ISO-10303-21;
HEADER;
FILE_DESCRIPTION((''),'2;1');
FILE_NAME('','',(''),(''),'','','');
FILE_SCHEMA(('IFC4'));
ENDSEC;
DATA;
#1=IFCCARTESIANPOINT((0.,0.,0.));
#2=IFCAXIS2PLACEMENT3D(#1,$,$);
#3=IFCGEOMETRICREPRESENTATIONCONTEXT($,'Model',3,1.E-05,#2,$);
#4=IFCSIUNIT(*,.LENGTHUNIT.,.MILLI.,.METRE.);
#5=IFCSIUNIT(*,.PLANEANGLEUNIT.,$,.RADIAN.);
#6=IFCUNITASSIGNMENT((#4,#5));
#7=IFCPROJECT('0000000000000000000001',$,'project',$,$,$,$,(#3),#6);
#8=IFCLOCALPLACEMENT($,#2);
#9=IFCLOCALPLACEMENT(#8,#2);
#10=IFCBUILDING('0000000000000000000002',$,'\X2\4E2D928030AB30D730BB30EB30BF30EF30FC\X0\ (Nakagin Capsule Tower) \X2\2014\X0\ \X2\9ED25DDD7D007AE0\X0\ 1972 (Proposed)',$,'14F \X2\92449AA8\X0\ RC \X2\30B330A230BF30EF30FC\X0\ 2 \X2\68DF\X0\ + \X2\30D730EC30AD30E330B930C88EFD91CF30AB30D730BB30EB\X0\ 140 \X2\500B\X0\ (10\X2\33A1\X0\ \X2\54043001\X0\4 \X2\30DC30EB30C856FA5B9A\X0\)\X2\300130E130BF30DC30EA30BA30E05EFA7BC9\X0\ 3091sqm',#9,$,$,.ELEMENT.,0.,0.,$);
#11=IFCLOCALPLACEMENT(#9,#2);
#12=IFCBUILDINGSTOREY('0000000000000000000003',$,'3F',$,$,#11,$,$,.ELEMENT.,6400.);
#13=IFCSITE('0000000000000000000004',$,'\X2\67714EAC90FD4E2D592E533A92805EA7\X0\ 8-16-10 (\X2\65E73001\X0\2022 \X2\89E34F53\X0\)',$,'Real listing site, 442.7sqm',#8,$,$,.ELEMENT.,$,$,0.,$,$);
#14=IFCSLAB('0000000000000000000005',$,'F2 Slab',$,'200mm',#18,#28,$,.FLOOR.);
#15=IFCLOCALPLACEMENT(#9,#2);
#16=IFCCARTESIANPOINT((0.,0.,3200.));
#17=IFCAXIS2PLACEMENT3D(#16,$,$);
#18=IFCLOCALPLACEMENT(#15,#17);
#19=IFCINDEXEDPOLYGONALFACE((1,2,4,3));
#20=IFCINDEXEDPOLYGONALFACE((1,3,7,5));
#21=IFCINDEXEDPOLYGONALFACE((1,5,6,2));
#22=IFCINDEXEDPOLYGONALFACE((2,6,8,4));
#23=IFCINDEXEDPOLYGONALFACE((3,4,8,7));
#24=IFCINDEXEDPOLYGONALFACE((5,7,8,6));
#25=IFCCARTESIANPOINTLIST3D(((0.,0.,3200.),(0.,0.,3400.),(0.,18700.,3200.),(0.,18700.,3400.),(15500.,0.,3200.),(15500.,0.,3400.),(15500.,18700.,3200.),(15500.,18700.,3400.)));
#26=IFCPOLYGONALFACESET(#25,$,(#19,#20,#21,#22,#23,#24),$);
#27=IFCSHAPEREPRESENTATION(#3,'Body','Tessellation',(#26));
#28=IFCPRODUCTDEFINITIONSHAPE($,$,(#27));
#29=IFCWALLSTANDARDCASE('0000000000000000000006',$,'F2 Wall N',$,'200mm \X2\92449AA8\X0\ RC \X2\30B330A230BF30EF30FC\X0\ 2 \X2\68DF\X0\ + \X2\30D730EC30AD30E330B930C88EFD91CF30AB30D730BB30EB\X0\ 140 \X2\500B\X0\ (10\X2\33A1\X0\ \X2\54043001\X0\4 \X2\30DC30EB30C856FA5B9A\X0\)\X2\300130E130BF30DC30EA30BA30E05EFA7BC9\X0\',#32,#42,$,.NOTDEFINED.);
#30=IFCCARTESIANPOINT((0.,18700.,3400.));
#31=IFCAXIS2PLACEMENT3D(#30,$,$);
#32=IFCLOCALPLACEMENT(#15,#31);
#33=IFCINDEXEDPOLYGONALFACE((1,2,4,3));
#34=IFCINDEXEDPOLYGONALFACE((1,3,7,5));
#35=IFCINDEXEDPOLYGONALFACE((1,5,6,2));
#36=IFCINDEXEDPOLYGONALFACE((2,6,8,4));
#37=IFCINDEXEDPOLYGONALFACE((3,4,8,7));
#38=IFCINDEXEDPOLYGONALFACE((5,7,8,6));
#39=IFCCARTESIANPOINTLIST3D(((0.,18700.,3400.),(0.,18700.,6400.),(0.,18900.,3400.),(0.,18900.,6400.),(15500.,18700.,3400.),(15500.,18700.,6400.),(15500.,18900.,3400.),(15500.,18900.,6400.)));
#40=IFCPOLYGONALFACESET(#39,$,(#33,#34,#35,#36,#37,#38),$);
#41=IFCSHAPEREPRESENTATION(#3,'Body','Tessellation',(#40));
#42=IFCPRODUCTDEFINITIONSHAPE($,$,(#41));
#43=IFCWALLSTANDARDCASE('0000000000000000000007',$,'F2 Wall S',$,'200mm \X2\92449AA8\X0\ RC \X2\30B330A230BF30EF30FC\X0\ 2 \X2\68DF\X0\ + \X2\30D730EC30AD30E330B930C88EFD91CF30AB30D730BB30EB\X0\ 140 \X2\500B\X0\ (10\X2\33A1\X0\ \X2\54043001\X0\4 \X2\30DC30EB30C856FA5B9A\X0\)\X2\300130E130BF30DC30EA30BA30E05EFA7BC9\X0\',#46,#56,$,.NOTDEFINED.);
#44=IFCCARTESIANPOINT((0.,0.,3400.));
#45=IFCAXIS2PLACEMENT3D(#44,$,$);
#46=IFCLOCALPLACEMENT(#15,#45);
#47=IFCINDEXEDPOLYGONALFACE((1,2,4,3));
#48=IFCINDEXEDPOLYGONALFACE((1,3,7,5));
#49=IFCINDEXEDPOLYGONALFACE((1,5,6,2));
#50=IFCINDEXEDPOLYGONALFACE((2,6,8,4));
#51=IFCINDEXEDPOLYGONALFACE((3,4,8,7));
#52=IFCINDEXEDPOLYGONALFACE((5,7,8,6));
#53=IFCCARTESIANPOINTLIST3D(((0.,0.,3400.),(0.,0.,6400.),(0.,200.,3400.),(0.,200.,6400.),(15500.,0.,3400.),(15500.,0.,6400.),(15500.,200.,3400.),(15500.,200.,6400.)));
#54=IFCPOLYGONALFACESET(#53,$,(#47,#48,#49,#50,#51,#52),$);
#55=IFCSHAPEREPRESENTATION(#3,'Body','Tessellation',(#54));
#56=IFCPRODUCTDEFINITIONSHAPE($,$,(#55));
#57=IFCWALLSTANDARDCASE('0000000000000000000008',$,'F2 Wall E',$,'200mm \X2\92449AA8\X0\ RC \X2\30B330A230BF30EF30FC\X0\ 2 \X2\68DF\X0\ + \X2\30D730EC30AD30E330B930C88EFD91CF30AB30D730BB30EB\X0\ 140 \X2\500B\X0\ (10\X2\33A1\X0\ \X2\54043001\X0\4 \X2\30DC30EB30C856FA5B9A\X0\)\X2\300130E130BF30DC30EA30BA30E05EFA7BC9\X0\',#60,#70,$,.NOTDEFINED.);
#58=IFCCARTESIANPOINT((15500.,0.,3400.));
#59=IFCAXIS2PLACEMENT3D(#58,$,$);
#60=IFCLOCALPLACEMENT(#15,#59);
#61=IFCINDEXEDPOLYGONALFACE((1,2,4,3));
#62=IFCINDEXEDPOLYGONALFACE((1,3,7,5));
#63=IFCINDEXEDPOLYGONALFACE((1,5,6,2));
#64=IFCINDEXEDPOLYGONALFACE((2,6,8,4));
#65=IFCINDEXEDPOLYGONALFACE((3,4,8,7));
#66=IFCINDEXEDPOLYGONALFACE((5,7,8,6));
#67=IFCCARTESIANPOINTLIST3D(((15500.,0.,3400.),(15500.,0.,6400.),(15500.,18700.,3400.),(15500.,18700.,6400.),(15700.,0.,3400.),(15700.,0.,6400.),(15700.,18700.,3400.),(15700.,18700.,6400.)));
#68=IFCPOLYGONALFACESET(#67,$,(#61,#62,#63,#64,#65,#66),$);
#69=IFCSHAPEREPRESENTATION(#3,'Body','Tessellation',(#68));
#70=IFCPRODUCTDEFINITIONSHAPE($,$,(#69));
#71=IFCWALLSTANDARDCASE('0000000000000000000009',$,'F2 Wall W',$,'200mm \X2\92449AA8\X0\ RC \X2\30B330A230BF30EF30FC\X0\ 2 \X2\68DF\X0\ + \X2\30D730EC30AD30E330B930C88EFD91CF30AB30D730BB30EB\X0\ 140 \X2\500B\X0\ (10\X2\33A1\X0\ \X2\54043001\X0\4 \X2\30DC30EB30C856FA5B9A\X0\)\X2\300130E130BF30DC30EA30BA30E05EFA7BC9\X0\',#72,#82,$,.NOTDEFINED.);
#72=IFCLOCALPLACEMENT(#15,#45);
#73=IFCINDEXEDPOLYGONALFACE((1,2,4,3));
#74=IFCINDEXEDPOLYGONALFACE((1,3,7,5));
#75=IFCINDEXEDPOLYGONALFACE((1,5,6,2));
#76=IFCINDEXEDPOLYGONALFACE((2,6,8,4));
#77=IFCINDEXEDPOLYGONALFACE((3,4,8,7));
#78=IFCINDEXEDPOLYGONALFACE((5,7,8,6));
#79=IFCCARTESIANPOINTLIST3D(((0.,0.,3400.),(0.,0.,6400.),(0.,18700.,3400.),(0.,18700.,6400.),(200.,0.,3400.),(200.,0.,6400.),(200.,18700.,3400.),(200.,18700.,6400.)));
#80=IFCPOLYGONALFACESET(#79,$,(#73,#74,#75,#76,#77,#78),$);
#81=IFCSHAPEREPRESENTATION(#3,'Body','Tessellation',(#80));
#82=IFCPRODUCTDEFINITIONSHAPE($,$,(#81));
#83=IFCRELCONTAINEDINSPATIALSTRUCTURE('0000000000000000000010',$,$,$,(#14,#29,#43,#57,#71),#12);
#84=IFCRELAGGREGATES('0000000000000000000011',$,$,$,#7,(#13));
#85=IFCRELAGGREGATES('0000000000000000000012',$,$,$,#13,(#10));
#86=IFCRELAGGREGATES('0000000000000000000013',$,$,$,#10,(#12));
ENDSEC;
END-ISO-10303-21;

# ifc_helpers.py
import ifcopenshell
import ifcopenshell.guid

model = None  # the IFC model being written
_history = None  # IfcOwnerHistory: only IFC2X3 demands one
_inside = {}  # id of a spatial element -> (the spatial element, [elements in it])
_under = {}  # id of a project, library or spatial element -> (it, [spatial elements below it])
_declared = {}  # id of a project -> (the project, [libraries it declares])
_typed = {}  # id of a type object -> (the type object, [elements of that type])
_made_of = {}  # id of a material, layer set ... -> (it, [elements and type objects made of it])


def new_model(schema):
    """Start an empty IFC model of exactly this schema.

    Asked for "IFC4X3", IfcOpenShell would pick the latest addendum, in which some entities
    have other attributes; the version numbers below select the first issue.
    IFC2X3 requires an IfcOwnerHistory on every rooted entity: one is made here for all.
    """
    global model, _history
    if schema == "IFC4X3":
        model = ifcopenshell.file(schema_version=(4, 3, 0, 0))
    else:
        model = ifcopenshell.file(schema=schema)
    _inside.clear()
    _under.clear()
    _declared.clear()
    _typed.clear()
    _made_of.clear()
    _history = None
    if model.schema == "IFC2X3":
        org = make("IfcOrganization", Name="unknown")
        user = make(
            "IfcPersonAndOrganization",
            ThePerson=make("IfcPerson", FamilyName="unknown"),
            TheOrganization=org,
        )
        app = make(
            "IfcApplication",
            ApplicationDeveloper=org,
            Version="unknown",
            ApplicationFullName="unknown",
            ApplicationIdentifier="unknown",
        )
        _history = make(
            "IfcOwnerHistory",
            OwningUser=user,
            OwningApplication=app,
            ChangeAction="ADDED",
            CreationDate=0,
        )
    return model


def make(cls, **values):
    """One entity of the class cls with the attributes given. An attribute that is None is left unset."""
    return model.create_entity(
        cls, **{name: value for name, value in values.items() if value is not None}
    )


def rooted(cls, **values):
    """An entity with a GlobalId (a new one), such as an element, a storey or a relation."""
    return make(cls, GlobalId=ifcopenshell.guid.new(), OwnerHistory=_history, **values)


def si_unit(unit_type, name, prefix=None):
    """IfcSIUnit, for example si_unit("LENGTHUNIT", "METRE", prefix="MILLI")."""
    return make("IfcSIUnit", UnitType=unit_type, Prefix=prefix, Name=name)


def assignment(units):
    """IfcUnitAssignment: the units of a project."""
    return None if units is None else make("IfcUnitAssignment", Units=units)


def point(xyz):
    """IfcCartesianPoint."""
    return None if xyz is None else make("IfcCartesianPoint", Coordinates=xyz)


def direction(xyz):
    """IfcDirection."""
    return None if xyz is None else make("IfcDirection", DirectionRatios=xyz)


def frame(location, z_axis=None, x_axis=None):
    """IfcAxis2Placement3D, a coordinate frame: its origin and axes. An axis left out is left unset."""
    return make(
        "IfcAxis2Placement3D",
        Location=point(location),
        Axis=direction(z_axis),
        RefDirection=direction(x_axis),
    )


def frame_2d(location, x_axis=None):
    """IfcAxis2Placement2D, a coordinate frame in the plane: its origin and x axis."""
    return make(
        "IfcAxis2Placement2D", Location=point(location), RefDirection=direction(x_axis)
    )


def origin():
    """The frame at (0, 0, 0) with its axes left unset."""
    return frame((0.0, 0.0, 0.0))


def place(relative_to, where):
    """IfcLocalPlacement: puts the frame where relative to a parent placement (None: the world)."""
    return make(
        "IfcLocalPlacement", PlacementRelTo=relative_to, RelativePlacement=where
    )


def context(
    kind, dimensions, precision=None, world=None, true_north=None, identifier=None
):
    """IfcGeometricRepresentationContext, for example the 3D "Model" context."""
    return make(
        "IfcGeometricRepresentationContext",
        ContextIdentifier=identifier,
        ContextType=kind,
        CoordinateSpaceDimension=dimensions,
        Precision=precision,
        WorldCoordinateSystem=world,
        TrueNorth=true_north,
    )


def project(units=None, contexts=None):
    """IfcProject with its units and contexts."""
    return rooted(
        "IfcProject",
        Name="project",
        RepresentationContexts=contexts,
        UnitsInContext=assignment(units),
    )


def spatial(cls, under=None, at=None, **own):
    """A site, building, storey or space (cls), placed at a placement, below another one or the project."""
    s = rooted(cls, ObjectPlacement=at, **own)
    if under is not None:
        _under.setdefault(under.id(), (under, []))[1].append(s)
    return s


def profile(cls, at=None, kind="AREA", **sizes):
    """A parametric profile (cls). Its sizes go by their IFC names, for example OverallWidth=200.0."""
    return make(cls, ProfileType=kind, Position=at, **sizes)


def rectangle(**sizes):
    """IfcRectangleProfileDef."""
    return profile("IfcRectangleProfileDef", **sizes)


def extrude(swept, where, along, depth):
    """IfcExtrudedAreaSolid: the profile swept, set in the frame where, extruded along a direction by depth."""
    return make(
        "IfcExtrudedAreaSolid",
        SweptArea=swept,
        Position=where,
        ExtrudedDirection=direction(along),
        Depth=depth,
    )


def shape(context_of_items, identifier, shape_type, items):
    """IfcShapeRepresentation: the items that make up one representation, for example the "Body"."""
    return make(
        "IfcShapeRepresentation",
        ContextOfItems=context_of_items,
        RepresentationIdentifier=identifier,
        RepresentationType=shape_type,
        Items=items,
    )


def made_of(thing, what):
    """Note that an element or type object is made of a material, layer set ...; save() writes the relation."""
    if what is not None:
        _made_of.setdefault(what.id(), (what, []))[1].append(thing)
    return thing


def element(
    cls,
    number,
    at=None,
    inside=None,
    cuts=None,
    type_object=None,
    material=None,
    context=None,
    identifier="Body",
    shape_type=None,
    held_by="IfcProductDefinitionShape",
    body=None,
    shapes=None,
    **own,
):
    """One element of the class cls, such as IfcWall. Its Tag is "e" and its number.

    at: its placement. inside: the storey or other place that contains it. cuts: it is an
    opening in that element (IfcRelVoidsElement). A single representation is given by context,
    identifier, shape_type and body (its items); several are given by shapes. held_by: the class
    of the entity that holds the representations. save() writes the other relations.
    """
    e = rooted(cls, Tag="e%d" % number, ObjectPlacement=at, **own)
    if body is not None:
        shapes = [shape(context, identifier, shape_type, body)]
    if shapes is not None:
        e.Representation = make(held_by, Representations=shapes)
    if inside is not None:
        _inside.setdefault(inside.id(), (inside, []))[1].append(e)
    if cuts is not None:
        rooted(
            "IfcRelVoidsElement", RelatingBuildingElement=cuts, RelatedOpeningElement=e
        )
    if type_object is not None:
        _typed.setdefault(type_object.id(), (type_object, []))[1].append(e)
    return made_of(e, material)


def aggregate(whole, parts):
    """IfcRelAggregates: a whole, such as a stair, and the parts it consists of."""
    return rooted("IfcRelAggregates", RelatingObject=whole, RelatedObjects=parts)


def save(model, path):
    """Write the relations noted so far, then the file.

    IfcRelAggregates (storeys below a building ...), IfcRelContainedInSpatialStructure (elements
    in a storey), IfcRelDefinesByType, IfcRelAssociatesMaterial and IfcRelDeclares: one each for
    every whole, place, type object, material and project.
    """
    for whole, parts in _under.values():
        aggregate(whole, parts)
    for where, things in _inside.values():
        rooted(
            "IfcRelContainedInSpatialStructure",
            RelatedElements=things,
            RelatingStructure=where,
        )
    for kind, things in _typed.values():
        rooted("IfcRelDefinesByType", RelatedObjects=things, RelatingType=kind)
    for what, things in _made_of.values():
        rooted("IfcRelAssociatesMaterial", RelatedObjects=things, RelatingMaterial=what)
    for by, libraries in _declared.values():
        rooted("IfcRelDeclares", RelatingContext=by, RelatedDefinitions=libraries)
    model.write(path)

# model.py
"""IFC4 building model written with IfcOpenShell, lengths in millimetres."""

from ifc_helpers import new_model, si_unit, frame, frame_2d, origin, place, context, project, spatial, rectangle, extrude, element, save


model = new_model("IFC4")

# Units and contexts
model_context = context("Model", 3, precision=1e-05, world=origin())
ifc_project = project(units=[si_unit("LENGTHUNIT", "METRE", prefix="MILLI"), si_unit("PLANEANGLEUNIT", "RADIAN")], contexts=[model_context])

# Site, building, storey
site_placement = place(None, origin())
site = spatial("IfcSite", under=ifc_project, at=site_placement, Name="東京都中央区銀座 8-16-10 (旧、2022 解体)", ObjectType="Real listing site, 442.7sqm", CompositionType="ELEMENT", RefElevation=0.0)
building_placement = place(site_placement, origin())
building = spatial("IfcBuilding", under=site, at=building_placement, Name="中銀カプセルタワー (Nakagin Capsule Tower) — 黒川紀章 1972 (Proposed)", ObjectType="14F 鉄骨 RC コアタワー 2 棟 + プレキャスト軽量カプセル 140 個 (10㎡ 各、4 ボルト固定)、メタボリズム建築 3091sqm", CompositionType="ELEMENT", ElevationOfRefHeight=0.0, ElevationOfTerrain=0.0)
storey_placement = place(building_placement, origin())
storey = spatial("IfcBuildingStorey", under=building, at=storey_placement, Name="3F", CompositionType="ELEMENT", Elevation=6400.0)

# Slab
placement = place(building_placement, origin())
slab_placement = place(placement, frame((0.0, 0.0, 3200.0)))
element("IfcSlab", 1, at=slab_placement, inside=storey, Name="F2 Slab", ObjectType="200mm", PredefinedType="FLOOR", context=model_context, shape_type="SweptSolid", body=[
    extrude(rectangle(XDim=15500.0, YDim=18700.0, at=frame_2d((7750.0, 9350.0))), frame((0.0, 0.0, 3200.0)), (0.0, 0.0, 1.0), 200.0),
])

# Walls
wall_1_placement = place(placement, frame((0.0, 18700.0, 3400.0)))
element("IfcWallStandardCase", 2, at=wall_1_placement, inside=storey, Name="F2 Wall N", ObjectType="200mm 鉄骨 RC コアタワー 2 棟 + プレキャスト軽量カプセル 140 個 (10㎡ 各、4 ボルト固定)、メタボリズム建築", PredefinedType="NOTDEFINED", context=model_context, shape_type="SweptSolid", body=[
    extrude(rectangle(XDim=15500.0, YDim=200.0, at=frame_2d((7750.0, 100.0))), frame((0.0, 18700.0, 3400.0)), (0.0, 0.0, 1.0), 3000.0),
])
wall_2_placement = place(placement, frame((0.0, 0.0, 3400.0)))
element("IfcWallStandardCase", 3, at=wall_2_placement, inside=storey, Name="F2 Wall S", ObjectType="200mm 鉄骨 RC コアタワー 2 棟 + プレキャスト軽量カプセル 140 個 (10㎡ 各、4 ボルト固定)、メタボリズム建築", PredefinedType="NOTDEFINED", context=model_context, shape_type="SweptSolid", body=[
    extrude(rectangle(XDim=15500.0, YDim=200.0, at=frame_2d((7750.0, 100.0))), frame((0.0, 0.0, 3400.0)), (0.0, 0.0, 1.0), 3000.0),
])
wall_3_placement = place(placement, frame((15500.0, 0.0, 3400.0)))
element("IfcWallStandardCase", 4, at=wall_3_placement, inside=storey, Name="F2 Wall E", ObjectType="200mm 鉄骨 RC コアタワー 2 棟 + プレキャスト軽量カプセル 140 個 (10㎡ 各、4 ボルト固定)、メタボリズム建築", PredefinedType="NOTDEFINED", context=model_context, shape_type="SweptSolid", body=[
    extrude(rectangle(XDim=200.0, YDim=18700.0, at=frame_2d((100.0, 9350.0))), frame((15500.0, 0.0, 3400.0)), (0.0, 0.0, 1.0), 3000.0),
])
wall_4_placement = place(placement, frame((0.0, 0.0, 3400.0)))
element("IfcWallStandardCase", 5, at=wall_4_placement, inside=storey, Name="F2 Wall W", ObjectType="200mm 鉄骨 RC コアタワー 2 棟 + プレキャスト軽量カプセル 140 個 (10㎡ 各、4 ボルト固定)、メタボリズム建築", PredefinedType="NOTDEFINED", context=model_context, shape_type="SweptSolid", body=[
    extrude(rectangle(XDim=200.0, YDim=18700.0, at=frame_2d((100.0, 9350.0))), frame((0.0, 0.0, 3400.0)), (0.0, 0.0, 1.0), 3000.0),
])

save(model, "model.ifc")
